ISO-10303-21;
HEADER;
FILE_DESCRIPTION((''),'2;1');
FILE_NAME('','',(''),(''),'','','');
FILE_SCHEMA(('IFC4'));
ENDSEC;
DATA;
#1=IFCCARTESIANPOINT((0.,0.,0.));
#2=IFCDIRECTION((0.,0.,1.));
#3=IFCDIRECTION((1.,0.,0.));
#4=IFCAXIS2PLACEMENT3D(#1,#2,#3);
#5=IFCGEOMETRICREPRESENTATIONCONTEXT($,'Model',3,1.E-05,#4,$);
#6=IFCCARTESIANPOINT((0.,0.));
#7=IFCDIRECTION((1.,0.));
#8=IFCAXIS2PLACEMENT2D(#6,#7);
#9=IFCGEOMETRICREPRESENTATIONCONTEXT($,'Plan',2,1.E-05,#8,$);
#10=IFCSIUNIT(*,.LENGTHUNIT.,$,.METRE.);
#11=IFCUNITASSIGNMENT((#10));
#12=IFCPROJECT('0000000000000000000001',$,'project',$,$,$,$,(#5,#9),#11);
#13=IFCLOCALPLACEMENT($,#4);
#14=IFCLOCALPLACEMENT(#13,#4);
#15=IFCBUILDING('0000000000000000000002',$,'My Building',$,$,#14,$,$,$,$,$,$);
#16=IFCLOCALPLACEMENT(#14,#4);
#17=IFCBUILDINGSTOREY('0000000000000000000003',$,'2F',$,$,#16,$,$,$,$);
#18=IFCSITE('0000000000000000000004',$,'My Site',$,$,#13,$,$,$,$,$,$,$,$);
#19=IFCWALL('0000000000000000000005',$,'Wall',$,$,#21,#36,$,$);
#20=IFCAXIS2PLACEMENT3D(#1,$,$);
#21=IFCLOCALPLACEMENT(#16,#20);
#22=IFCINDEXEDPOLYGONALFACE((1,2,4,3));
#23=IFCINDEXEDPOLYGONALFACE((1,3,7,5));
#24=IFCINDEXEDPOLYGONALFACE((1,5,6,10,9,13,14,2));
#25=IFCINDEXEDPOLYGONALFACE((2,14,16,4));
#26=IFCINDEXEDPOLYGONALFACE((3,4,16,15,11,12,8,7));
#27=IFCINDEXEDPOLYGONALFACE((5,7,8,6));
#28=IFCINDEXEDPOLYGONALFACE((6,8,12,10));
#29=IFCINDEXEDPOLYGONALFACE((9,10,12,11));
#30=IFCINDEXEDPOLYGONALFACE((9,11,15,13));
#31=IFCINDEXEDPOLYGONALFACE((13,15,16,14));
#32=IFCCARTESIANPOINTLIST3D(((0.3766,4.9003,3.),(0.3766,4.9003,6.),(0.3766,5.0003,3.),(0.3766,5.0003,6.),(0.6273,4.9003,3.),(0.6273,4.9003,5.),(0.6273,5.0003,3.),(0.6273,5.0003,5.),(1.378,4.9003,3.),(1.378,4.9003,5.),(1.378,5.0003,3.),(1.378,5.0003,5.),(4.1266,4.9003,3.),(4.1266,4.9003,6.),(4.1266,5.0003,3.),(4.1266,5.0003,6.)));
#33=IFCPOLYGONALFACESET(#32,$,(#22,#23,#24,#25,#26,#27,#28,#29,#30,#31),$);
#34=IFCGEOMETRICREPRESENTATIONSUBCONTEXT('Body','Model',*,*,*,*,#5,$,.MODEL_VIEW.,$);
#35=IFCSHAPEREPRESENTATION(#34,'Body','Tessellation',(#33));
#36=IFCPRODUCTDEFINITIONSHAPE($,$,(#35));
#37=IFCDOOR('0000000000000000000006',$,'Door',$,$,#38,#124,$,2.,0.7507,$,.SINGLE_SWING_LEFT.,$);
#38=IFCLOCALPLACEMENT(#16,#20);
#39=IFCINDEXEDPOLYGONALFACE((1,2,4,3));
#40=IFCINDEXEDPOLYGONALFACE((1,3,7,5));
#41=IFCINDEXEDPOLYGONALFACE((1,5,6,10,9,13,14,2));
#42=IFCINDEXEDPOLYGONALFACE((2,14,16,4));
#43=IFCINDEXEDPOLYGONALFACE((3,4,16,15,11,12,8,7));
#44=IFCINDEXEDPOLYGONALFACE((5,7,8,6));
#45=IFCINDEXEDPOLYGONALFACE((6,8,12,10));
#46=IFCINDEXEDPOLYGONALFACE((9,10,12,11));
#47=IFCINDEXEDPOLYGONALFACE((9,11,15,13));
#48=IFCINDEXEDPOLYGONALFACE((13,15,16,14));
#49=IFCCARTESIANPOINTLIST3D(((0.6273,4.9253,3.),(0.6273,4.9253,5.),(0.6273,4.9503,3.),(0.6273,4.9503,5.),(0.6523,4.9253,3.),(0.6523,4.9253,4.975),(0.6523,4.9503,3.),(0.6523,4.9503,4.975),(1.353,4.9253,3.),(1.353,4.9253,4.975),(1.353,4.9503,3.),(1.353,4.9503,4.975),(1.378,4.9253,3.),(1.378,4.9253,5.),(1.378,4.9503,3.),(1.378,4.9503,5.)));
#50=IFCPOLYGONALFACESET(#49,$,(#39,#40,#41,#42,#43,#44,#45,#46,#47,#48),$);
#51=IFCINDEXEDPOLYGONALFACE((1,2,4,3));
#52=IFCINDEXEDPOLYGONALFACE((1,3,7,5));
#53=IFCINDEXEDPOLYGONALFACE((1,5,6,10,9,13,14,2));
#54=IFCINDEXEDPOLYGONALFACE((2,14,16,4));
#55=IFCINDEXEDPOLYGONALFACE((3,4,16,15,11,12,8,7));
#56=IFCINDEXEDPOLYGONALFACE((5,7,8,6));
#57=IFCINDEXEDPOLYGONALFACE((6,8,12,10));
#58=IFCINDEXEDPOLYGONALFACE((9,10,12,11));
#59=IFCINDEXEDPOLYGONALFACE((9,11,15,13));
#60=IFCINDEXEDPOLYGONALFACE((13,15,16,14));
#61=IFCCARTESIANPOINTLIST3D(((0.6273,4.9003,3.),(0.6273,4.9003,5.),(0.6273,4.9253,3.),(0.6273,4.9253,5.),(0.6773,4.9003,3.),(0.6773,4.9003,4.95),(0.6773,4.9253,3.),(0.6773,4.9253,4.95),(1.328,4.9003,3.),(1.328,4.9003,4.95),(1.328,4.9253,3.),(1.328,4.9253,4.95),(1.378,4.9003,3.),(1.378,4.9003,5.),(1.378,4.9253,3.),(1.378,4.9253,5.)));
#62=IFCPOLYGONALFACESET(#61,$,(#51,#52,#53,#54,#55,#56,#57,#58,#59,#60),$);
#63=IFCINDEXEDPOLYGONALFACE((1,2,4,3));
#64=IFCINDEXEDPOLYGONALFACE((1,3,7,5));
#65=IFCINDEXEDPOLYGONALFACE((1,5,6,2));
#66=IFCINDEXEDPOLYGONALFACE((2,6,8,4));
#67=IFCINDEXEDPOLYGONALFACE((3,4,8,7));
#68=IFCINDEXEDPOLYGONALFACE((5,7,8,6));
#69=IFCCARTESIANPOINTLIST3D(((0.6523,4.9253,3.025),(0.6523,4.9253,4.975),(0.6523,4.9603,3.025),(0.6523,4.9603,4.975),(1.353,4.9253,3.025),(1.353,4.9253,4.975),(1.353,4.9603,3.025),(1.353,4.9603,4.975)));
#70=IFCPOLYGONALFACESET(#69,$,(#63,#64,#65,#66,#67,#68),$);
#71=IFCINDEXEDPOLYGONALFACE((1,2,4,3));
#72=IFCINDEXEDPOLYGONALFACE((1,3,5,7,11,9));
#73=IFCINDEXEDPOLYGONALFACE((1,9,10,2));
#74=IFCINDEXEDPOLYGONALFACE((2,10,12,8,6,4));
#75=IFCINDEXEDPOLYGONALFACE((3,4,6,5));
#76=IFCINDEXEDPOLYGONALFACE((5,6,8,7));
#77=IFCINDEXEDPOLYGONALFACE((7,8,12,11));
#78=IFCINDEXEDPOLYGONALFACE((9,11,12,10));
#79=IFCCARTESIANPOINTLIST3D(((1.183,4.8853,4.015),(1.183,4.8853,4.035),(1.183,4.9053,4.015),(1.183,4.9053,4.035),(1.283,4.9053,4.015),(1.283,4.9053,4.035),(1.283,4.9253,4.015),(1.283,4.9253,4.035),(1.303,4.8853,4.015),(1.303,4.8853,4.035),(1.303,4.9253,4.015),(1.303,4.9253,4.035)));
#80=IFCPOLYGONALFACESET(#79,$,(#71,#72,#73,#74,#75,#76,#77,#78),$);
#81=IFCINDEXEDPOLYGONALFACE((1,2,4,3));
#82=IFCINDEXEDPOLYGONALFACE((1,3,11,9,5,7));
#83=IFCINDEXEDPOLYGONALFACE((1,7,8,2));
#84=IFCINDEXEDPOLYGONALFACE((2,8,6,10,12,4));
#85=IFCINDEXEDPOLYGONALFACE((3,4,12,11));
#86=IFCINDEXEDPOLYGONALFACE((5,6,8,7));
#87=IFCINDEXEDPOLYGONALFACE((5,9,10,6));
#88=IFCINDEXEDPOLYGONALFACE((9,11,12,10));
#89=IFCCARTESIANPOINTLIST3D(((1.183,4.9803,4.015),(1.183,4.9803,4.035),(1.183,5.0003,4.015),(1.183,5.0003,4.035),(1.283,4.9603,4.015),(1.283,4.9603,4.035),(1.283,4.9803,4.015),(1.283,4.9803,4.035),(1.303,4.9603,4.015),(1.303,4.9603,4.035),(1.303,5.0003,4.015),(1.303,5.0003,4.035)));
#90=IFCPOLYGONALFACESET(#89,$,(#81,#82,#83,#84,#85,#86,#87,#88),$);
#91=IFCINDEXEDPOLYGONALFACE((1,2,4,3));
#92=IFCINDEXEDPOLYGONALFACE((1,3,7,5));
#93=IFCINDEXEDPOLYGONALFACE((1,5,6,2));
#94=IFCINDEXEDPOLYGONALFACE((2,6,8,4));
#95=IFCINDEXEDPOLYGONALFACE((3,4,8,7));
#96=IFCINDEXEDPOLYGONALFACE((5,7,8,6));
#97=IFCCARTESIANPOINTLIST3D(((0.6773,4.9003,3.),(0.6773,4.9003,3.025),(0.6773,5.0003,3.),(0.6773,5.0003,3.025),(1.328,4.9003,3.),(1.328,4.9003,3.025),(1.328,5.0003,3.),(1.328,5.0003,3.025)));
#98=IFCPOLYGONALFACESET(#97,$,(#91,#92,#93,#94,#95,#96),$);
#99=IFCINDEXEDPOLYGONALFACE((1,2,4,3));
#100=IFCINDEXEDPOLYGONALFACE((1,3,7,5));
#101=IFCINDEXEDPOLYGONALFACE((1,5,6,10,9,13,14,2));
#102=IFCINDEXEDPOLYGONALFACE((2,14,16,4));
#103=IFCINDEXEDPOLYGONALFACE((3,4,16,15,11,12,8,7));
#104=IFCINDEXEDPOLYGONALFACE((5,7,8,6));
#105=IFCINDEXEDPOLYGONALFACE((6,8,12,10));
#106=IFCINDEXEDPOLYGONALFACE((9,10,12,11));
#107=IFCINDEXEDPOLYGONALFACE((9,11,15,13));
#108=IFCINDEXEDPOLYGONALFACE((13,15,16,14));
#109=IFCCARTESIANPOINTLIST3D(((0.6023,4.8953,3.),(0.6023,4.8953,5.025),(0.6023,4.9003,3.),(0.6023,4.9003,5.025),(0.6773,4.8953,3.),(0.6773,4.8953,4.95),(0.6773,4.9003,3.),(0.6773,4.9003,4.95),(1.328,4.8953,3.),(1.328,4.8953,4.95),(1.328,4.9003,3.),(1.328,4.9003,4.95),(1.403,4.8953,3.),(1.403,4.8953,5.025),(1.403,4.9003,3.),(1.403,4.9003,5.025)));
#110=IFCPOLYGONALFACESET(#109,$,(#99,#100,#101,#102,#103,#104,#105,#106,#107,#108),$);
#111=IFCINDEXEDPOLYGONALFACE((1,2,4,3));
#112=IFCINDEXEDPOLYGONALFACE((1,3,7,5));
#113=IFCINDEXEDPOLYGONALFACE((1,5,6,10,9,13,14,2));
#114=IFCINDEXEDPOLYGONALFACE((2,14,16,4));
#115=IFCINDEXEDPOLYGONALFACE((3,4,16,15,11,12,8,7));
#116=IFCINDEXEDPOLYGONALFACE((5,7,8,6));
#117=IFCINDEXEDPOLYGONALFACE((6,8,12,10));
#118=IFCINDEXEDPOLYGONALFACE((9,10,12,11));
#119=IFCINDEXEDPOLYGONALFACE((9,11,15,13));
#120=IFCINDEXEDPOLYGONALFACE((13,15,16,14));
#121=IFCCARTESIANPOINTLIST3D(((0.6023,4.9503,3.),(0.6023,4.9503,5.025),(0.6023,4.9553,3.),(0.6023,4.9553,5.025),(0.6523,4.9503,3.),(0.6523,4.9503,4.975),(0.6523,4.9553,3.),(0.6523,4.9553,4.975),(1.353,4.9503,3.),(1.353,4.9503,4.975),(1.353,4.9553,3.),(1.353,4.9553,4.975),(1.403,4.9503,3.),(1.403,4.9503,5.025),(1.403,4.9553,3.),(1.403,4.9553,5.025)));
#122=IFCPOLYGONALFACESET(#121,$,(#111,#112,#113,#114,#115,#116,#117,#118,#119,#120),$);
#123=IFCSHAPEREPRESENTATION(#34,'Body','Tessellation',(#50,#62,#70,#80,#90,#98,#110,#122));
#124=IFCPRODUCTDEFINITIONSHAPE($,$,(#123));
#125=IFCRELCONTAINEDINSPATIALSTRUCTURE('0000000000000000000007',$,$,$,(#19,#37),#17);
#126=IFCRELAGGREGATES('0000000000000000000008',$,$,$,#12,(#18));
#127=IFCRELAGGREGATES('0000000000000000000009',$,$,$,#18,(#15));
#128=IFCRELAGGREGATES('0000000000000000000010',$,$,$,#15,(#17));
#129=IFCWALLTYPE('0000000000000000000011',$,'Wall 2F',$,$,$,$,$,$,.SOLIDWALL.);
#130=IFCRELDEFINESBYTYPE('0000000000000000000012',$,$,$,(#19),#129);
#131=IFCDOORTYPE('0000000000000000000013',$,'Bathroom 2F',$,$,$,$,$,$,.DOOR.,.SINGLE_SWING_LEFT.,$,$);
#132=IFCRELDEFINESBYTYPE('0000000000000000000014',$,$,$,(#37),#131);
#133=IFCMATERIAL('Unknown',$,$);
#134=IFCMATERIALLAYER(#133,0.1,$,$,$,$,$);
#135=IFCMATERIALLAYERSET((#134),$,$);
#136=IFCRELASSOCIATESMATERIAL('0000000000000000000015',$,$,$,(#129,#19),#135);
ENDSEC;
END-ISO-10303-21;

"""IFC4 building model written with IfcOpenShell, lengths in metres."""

from ifc_helpers import new_model, entity, si_unit, frame, origin_with_axes, origin_2d_with_axis, place, context, subcontext, project, spatial, line, indexed_curve, outline, extrude, shape, source, transform, mapped, material, layer, layer_set, layer_usage, type_object, type_shapes, element, fill, save


model = new_model("IFC4")

# Units and contexts
model_context = context("Model", 3, precision=1e-05, world=origin_with_axes())
plan_context = context("Plan", 2, precision=1e-05, world=origin_2d_with_axis())
body_context_1 = subcontext(model_context, "Body", "Model", "MODEL_VIEW")
body_context_2 = subcontext(plan_context, "Body", "Plan", "PLAN_VIEW")
ifc_project = project(units=[si_unit("LENGTHUNIT", "METRE")], contexts=[model_context, plan_context])

# Site, building, storey
site_placement = place(None, origin_with_axes())
site = spatial("IfcSite", under=ifc_project, at=site_placement, Name="My Site")
building_placement = place(site_placement, origin_with_axes())
building = spatial("IfcBuilding", under=site, at=building_placement, Name="My Building")
storey_placement = place(building_placement, origin_with_axes())
storey = spatial("IfcBuildingStorey", under=building, at=storey_placement, Name="2F")

# Shared definitions
ifc_material = material(Name="Unknown")

# Shared definitions
ifc_layer = layer(ifc_material, 0.1)
ifc_layer_set = layer_set([ifc_layer])
wall_type = type_object("IfcWallType", Name="Wall 2F", PredefinedType="SOLIDWALL", material=ifc_layer_set)

# Wall, opening, door
ifc_layer_usage_1 = layer_usage(ifc_layer_set, "AXIS2", "POSITIVE", 0.0)
wall_1_placement = place(storey_placement, frame((4.2266, 5.0003, 3.0), z_axis=(0.0, 0.0, 1.0), x_axis=(-1.0, 0.0, 0.0)))
wall_1 = element("IfcWall", 1, at=wall_1_placement, inside=storey, type_object=wall_type, material=ifc_layer_usage_1, Name="Wall", context=body_context_1, shape_type="SweptSolid", body=[
    extrude(outline(indexed_curve([(0.1, 0.0), (0.1, 0.1), (3.85, 0.1), (3.85, 0.0)], segments=[line(1, 2, 3, 4, 1)])), origin_with_axes(), (0.0, 0.0, 1.0), 3.0),
])
shared_shape_1 = source(origin_with_axes(), body_context_1, "Body", "SweptSolid", [
    extrude(outline(indexed_curve([(0.0, 0.0), (0.7507, 0.0), (0.7507, 2.0), (0.0, 2.0)], segments=[line(1, 2, 3, 4, 1)])), frame((0.0, -0.6, 0.0), z_axis=(0.0, -1.0, 0.0), x_axis=(1.0, 0.0, 0.0)), (0.0, 0.0, -1.0), 1.2),
])
opening_1_placement = place(wall_1_placement, frame((3.5993, 0.1, 0.0), z_axis=(0.0, 0.0, 1.0), x_axis=(-1.0, 0.000001, 0.0)))
opening_1 = element("IfcOpeningElement", 2, at=opening_1_placement, cuts=wall_1, PredefinedType="OPENING", context=body_context_1, shape_type="MappedRepresentation", body=[
    mapped(shared_shape_1, transform((0.0, 0.0, 0.0), x_axis=(1.0, 0.0, 0.0), y_axis=(0.0, 1.0, 0.0), z_axis=(0.0, 0.0, 1.0), scale=1.0)),
])
door_type = type_object("IfcDoorType", Name="Bathroom 2F", OperationType="SINGLE_SWING_LEFT", PredefinedType="DOOR")
shared_shape_2 = source(origin_with_axes(), body_context_1, "Body", "SweptSolid", [
    extrude(outline(indexed_curve([(0.0, 0.0), (0.0, 2.0), (0.7507, 2.0), (0.7507, 0.0), (0.7257, 0.0), (0.7257, 1.975), (0.025, 1.975), (0.025, 0.0)], segments=[line(1, 2, 3, 4, 5, 6, 7, 8, 1)])), frame((0.0, 0.025, 0.0), z_axis=(0.0, -1.0, 0.0), x_axis=(1.0, 0.0, 0.0)), (0.0, 0.0, -1.0), 0.025),
    extrude(outline(indexed_curve([(0.0, 0.0), (0.0, 2.0), (0.7507, 2.0), (0.7507, 0.0), (0.7007, 0.0), (0.7007, 1.95), (0.05, 1.95), (0.05, 0.0)], segments=[line(1, 2, 3, 4, 5, 6, 7, 8, 1)])), frame((0.0, 0.0, 0.0), z_axis=(0.0, -1.0, 0.0), x_axis=(1.0, 0.0, 0.0)), (0.0, 0.0, -1.0), 0.025),
    extrude(outline(indexed_curve([(0.0, 0.0), (0.7007, 0.0), (0.7007, 0.035), (0.0, 0.035)], segments=[line(1, 2, 3, 4, 1)])), frame((0.025, 0.025, 0.025), z_axis=(0.0, 0.0, 1.0), x_axis=(1.0, 0.0, 0.0)), (0.0, 0.0, 1.0), 1.95),
    extrude(outline(indexed_curve([(0.0, 0.0), (0.0, -0.04), (-0.12, -0.04), (-0.12, -0.02), (-0.02, -0.02), (-0.02, 0.0)], segments=[line(1, 2, 3, 4, 5, 6, 1)])), frame((0.6757, 0.025, 1.015), z_axis=(0.0, 0.0, 1.0), x_axis=(1.0, 0.0, 0.0)), (0.0, 0.0, 1.0), 0.02),
    extrude(outline(indexed_curve([(0.0, 0.0), (0.0, 0.04), (-0.12, 0.04), (-0.12, 0.02), (-0.02, 0.02), (-0.02, 0.0)], segments=[line(1, 2, 3, 4, 5, 6, 1)])), frame((0.6757, 0.06, 1.015), z_axis=(0.0, 0.0, 1.0), x_axis=(1.0, 0.0, 0.0)), (0.0, 0.0, 1.0), 0.02),
    extrude(outline(indexed_curve([(0.0, 0.0), (0.6507, 0.0), (0.6507, 0.1), (0.0, 0.1)], segments=[line(1, 2, 3, 4, 1)])), frame((0.05, 0.0, 0.0), z_axis=(0.0, 0.0, 1.0), x_axis=(1.0, 0.0, 0.0)), (0.0, 0.0, 1.0), 0.025),
    extrude(outline(indexed_curve([(0.0, 0.0), (0.0, 2.025), (0.8007, 2.025), (0.8007, 0.0), (0.7257, 0.0), (0.7257, 1.95), (0.075, 1.95), (0.075, 0.0)], segments=[line(1, 2, 3, 4, 5, 6, 7, 8, 1)])), frame((-0.025, -0.005, 0.0), z_axis=(0.0, -1.0, 0.0), x_axis=(1.0, 0.0, 0.0)), (0.0, 0.0, -1.0), 0.005),
    extrude(outline(indexed_curve([(0.0, 0.0), (0.0, 2.025), (0.8007, 2.025), (0.8007, 0.0), (0.7507, 0.0), (0.7507, 1.975), (0.05, 1.975), (0.05, 0.0)], segments=[line(1, 2, 3, 4, 5, 6, 7, 8, 1)])), frame((-0.025, 0.05, 0.0), z_axis=(0.0, -1.0, 0.0), x_axis=(1.0, 0.0, 0.0)), (0.0, 0.0, -1.0), 0.005),
])
shared_shape_3 = source(origin_with_axes(), body_context_2, "Body", "Curve2D", [
    entity("IfcIndexedPolyCurve", entity("IfcCartesianPointList2D", [[0.0, 0.0], [0.0, 0.05], [0.025, 0.05], [0.025, 0.025], [0.05, 0.025], [0.05, 0.0]]), [entity("IfcLineIndex", [1, 2, 3, 4, 5, 6, 1])]),
    entity("IfcIndexedPolyCurve", entity("IfcCartesianPointList2D", [[0.7507, 0.0], [0.7507, 0.05], [0.7257, 0.05], [0.7257, 0.025], [0.7007, 0.025], [0.7007, 0.0]]), [entity("IfcLineIndex", [1, 2, 3, 4, 5, 6, 1])]),
    entity("IfcTrimmedCurve", entity("IfcEllipse", entity("IfcAxis2Placement2D", entity("IfcCartesianPoint", [0.06, 0.05]), entity("IfcDirection", [1.0, 0.0])), 0.6657, 0.7007), [entity("IfcCartesianPoint", [0.7257, 0.05])], [entity("IfcCartesianPoint", [0.06, 0.7507])], True, "CARTESIAN"),
    entity("IfcIndexedPolyCurve", entity("IfcCartesianPointList2D", [[0.025, 0.05], [0.06, 0.05], [0.06, 0.7507], [0.025, 0.7507]]), [entity("IfcLineIndex", [1, 2, 3, 4, 1])]),
])
type_shapes(door_type, [shared_shape_2, shared_shape_3])
door_placement = place(opening_1_placement, frame((0.0, 0.0, 0.0), z_axis=(0.0, 0.0, 1.0), x_axis=(1.0, 0.0, 0.0)))
door = element("IfcDoor", 3, at=door_placement, inside=storey, type_object=door_type, Name="Door", OperationType="SINGLE_SWING_LEFT", OverallHeight=2.0, OverallWidth=0.7507, shapes=[
    shape(body_context_1, "Body", "MappedRepresentation", [mapped(shared_shape_2, transform((0.0, 0.0, 0.0), x_axis=(1.0, 0.0, 0.0), y_axis=(0.0, 1.0, 0.0), z_axis=(0.0, 0.0, 1.0), scale=1.0))]),
    shape(body_context_2, "Body", "MappedRepresentation", [mapped(shared_shape_3, transform((0.0, 0.0, 0.0), x_axis=(1.0, 0.0, 0.0), y_axis=(0.0, 1.0, 0.0), z_axis=(0.0, 0.0, 1.0), scale=1.0))]),
])
fill(opening_1, door)

save(model, "model.ifc")
